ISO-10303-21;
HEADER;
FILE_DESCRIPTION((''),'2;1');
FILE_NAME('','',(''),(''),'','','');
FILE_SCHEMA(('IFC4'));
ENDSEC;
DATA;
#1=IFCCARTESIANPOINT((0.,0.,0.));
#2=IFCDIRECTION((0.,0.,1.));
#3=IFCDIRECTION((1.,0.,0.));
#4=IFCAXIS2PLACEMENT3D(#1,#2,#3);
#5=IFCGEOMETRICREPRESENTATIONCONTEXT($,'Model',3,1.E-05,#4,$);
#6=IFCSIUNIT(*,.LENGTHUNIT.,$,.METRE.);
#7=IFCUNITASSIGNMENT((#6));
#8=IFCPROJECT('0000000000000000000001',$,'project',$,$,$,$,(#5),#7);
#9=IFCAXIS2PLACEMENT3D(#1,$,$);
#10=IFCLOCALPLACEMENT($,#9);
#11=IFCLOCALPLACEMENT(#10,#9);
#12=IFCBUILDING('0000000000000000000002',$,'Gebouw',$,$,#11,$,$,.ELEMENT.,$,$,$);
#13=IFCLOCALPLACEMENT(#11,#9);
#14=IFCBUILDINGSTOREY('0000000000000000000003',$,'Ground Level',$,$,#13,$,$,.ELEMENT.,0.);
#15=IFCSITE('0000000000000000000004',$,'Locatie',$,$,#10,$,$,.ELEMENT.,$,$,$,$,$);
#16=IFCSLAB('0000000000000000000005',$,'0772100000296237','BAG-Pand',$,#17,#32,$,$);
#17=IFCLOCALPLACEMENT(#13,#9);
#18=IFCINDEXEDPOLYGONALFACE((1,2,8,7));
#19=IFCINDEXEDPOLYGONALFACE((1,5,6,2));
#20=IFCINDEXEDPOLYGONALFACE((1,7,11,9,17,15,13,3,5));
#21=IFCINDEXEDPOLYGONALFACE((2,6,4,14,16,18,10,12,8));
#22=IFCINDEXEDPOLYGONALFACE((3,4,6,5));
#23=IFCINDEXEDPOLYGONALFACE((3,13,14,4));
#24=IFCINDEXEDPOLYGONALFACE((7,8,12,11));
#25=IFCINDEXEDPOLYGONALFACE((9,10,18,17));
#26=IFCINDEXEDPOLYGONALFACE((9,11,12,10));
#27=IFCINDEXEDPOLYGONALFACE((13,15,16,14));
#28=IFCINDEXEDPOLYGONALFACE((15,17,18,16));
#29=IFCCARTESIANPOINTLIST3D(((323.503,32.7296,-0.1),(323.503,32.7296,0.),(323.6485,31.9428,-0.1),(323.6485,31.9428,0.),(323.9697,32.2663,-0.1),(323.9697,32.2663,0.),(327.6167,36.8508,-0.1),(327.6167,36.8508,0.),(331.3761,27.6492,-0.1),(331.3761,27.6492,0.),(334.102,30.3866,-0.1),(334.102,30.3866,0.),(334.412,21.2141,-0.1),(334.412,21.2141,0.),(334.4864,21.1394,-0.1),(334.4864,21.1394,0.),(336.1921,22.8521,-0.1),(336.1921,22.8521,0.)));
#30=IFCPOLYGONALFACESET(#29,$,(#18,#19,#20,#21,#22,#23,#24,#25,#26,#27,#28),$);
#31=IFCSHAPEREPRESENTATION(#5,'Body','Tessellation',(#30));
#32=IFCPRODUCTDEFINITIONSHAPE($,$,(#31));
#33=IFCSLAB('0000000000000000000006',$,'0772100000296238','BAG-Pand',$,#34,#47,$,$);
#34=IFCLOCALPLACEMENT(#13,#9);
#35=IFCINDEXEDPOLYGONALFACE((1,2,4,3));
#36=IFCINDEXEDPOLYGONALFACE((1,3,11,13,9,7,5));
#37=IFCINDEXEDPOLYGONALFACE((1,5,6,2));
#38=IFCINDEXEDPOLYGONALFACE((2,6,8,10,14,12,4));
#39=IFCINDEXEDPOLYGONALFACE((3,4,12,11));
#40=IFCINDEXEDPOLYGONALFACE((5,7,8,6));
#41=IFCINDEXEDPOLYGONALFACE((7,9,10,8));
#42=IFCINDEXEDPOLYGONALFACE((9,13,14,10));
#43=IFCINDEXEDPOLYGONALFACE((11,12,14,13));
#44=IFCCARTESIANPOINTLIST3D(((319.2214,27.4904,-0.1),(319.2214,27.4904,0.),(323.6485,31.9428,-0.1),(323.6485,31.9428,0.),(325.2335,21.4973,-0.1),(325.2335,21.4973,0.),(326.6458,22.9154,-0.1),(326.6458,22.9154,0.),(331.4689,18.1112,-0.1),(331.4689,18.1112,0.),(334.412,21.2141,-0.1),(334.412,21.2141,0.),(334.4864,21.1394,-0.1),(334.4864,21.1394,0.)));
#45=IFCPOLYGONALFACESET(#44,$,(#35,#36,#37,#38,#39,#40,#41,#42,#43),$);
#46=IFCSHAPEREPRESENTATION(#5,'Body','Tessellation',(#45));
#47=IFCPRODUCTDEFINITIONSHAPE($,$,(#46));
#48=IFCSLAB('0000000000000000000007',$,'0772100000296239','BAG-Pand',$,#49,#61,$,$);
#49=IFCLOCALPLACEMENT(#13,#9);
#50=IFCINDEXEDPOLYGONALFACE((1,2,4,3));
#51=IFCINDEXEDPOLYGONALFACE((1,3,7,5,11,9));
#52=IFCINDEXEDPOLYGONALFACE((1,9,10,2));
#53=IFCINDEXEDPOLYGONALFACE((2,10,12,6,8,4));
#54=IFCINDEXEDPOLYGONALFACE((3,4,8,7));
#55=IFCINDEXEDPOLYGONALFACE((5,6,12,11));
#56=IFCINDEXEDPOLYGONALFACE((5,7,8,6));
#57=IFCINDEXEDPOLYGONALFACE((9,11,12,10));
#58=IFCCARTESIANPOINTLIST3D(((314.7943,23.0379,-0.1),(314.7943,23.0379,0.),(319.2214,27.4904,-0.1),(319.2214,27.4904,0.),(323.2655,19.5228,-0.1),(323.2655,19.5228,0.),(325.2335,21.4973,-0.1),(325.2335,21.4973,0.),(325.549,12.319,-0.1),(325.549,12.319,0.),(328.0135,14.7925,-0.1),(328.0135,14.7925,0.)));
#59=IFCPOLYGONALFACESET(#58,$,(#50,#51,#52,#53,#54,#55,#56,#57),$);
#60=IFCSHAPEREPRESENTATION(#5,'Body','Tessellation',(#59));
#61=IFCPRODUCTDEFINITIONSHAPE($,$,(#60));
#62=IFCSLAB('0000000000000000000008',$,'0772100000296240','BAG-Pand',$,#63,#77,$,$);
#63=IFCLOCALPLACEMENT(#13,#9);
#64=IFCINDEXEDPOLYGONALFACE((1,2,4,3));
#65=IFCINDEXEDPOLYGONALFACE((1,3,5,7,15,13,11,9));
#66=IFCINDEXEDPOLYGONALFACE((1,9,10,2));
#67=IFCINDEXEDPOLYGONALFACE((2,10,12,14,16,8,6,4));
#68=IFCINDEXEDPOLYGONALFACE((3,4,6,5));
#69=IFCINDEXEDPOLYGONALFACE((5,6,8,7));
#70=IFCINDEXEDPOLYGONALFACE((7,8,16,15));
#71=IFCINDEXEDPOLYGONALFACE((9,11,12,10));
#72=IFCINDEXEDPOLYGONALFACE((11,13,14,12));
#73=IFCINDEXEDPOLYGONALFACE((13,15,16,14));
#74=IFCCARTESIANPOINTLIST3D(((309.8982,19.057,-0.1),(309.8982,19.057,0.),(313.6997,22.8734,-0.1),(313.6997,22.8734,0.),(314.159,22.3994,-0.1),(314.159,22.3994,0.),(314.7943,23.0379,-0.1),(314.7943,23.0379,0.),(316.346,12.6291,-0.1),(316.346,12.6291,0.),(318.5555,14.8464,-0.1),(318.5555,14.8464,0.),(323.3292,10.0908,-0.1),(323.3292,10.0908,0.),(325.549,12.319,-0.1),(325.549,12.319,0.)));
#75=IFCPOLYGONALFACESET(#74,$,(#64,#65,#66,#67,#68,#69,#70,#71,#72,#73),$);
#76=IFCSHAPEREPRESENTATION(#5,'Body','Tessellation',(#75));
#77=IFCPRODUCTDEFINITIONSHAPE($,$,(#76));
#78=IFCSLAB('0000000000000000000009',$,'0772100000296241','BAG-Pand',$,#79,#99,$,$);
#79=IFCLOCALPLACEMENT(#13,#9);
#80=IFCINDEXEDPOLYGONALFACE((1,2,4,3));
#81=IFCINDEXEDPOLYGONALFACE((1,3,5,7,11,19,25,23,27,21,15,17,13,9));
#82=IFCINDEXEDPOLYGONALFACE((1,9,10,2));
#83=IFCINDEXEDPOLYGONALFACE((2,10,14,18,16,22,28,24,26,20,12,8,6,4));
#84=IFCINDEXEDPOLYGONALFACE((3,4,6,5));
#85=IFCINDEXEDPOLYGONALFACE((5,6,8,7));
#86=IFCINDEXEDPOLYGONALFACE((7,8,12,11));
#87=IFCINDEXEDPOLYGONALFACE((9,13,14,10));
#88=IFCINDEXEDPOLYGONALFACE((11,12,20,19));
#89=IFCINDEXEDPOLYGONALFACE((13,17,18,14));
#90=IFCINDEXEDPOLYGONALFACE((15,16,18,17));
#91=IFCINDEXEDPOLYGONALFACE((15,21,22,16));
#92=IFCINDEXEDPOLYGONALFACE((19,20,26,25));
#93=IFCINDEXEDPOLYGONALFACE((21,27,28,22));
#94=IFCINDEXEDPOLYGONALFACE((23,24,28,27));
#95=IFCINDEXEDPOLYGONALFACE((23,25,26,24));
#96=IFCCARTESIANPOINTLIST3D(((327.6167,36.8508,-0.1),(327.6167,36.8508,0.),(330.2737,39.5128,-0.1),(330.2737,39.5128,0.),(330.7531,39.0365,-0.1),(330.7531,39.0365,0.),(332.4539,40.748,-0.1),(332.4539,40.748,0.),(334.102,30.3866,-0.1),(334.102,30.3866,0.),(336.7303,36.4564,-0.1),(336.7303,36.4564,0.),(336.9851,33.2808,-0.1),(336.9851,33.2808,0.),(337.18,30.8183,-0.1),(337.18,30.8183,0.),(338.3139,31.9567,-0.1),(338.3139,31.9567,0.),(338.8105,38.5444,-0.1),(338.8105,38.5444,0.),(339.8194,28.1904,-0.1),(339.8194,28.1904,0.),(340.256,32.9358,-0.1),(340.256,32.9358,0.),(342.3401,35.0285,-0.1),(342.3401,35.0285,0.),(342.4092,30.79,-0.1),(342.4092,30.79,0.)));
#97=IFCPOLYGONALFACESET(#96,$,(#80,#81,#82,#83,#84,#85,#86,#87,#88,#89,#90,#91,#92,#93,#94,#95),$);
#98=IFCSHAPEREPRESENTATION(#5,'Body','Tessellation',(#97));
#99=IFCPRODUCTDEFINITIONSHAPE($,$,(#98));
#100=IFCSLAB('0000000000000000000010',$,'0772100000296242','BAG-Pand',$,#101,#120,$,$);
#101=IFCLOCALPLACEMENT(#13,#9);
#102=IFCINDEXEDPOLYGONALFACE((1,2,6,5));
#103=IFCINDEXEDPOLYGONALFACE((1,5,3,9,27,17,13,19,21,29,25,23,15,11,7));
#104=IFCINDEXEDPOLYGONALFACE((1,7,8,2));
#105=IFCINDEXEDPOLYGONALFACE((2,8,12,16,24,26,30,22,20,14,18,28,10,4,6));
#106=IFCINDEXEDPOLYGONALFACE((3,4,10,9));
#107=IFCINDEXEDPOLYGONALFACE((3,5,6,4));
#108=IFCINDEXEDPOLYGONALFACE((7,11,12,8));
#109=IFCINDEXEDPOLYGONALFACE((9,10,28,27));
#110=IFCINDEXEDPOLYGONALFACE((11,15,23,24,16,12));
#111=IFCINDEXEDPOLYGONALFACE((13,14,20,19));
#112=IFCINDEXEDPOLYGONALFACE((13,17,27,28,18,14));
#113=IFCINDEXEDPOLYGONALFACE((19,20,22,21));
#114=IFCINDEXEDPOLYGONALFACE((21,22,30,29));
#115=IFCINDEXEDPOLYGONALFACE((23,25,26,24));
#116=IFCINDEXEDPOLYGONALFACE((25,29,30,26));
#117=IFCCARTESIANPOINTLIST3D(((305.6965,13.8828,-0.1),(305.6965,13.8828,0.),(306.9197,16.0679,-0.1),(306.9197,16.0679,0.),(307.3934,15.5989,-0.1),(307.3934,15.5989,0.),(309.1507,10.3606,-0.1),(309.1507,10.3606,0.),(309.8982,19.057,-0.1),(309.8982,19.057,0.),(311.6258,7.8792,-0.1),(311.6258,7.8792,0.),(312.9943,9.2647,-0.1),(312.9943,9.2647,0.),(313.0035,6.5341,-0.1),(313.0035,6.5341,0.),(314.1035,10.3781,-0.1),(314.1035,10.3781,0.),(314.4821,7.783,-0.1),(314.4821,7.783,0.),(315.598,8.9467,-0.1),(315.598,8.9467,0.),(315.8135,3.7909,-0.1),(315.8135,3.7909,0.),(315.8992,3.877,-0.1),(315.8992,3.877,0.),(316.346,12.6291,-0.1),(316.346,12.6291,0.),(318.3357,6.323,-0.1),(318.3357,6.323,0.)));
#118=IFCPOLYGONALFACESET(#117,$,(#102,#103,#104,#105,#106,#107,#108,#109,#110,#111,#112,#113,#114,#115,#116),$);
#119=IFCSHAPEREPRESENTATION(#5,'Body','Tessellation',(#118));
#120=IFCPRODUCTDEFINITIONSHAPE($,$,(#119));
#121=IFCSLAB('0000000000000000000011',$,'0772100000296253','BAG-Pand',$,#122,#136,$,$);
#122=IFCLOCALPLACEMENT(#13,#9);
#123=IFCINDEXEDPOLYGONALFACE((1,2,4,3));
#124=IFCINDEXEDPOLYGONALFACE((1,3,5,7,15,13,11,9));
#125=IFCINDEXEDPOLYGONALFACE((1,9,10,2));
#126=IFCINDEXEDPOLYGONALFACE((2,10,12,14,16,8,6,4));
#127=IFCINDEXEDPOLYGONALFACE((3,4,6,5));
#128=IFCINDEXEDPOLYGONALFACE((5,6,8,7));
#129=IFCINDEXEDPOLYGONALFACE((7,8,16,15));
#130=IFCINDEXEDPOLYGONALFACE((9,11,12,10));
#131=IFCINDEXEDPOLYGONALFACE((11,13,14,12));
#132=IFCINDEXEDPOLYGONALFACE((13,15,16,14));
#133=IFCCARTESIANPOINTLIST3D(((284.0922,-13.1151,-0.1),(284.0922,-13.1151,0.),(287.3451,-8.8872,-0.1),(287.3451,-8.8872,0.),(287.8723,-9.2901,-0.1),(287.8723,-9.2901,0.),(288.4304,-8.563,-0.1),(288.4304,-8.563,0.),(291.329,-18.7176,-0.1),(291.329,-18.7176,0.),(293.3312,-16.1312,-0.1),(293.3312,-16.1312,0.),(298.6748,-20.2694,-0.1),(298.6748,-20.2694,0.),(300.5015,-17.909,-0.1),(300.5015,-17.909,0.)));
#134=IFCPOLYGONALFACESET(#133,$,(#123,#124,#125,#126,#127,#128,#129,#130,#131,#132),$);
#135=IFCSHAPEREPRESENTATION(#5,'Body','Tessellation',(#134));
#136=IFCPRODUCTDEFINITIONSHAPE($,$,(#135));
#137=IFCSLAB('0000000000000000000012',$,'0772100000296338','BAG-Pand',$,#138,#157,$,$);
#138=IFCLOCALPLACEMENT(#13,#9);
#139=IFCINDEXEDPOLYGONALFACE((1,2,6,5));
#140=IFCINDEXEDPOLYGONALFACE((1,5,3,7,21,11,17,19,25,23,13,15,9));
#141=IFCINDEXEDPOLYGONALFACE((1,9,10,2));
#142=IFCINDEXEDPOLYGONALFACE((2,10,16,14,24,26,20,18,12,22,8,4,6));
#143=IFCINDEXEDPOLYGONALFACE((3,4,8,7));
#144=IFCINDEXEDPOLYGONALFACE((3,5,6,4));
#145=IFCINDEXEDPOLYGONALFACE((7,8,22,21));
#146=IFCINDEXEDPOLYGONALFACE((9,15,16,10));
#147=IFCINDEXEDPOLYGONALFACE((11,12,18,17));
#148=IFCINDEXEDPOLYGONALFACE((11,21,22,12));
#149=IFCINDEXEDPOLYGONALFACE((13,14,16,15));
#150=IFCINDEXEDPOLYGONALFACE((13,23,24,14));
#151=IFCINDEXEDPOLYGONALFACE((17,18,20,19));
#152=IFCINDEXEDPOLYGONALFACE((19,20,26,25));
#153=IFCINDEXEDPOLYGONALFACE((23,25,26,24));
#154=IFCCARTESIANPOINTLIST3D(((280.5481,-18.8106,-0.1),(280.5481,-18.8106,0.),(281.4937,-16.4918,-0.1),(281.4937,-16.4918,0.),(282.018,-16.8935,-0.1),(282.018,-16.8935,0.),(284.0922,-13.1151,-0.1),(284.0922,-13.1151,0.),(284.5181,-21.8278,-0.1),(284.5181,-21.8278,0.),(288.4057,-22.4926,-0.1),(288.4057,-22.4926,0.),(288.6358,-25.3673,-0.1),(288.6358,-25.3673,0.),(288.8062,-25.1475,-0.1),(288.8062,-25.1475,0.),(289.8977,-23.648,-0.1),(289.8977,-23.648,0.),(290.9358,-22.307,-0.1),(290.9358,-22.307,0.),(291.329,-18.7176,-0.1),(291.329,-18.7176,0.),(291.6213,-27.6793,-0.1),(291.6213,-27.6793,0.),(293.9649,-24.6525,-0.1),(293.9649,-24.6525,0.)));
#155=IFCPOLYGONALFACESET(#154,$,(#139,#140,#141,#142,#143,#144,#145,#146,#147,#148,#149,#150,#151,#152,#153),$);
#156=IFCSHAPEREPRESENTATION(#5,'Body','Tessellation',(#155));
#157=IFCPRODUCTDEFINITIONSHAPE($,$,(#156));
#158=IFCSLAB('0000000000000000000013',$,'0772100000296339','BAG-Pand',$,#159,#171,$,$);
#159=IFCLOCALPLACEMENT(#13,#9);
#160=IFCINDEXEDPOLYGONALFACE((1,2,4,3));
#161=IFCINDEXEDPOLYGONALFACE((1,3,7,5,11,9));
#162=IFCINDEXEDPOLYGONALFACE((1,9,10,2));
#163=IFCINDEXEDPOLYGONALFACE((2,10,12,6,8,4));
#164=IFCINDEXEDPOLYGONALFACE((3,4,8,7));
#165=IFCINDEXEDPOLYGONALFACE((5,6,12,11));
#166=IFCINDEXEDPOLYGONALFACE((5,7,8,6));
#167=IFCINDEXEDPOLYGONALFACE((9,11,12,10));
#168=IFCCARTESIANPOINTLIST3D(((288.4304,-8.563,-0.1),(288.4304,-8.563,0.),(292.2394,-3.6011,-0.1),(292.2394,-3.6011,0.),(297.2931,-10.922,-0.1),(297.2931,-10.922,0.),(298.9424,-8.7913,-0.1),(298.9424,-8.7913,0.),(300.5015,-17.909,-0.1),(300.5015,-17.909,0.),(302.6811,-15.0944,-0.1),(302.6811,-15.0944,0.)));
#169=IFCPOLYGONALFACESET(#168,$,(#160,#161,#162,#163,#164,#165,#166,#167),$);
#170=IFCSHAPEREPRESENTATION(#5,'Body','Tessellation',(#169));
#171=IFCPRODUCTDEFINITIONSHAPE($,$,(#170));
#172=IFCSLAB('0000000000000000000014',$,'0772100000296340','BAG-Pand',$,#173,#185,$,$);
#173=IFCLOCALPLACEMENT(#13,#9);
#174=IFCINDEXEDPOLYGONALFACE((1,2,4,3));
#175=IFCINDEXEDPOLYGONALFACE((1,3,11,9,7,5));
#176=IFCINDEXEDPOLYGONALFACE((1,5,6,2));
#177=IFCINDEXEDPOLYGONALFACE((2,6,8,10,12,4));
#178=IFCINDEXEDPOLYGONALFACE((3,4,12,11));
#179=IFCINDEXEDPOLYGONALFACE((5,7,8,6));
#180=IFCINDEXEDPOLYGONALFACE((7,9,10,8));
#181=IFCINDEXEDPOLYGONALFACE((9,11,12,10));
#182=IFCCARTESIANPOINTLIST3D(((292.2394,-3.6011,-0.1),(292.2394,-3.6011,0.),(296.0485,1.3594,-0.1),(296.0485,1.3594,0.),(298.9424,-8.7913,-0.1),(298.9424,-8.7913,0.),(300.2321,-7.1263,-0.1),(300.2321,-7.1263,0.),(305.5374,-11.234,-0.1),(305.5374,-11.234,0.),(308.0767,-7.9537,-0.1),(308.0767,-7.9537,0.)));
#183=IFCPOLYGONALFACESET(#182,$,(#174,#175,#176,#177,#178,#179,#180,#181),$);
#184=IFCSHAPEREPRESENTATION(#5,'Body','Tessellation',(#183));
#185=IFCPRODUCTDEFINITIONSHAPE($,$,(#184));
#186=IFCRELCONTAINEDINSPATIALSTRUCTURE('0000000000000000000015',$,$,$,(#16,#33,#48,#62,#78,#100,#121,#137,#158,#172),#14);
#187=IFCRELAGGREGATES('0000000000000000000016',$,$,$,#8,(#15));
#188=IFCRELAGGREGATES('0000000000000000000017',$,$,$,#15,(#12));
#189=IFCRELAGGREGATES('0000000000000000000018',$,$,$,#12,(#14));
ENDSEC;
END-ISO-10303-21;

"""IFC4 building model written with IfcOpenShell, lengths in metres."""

from ifc_helpers import new_model, si_unit, frame, origin, origin_with_axes, place, context, project, spatial, polyline, outline, extrude, element, save


model = new_model("IFC4")

# Units and contexts
model_context = context("Model", 3, precision=1e-05, world=origin_with_axes())
ifc_project = project(units=[si_unit("LENGTHUNIT", "METRE")], contexts=[model_context])

# Site, building, storey
site_placement = place(None, origin())
site = spatial("IfcSite", under=ifc_project, at=site_placement, Name="Locatie", CompositionType="ELEMENT")
building_placement = place(site_placement, origin())
building = spatial("IfcBuilding", under=site, at=building_placement, Name="Gebouw", CompositionType="ELEMENT")
storey_placement = place(building_placement, origin())
storey = spatial("IfcBuildingStorey", under=building, at=storey_placement, Name="Ground Level", CompositionType="ELEMENT", Elevation=0.0)

# Slabs
slab_1_placement = place(storey_placement, origin())
element("IfcSlab", 1, at=slab_1_placement, inside=storey, Name="0772100000296237", Description="BAG-Pand", context=model_context, shape_type="SweptSolid", body=[
    extrude(outline(polyline([(334.412, 21.2141), (323.6485, 31.9428), (323.9697, 32.2663), (323.503, 32.7296), (327.6167, 36.8508), (334.102, 30.3866), (331.3761, 27.6492), (336.1921, 22.8521), (334.4864, 21.1394), (334.412, 21.2141)])), frame((0.0, 0.0, -0.1), z_axis=(0.0, 0.0, 1.0), x_axis=(1.0, 0.0, 0.0)), (0.0, 0.0, 1.0), 0.1),
])
slab_2_placement = place(storey_placement, origin())
element("IfcSlab", 2, at=slab_2_placement, inside=storey, Name="0772100000296238", Description="BAG-Pand", context=model_context, shape_type="SweptSolid", body=[
    extrude(outline(polyline([(319.2214, 27.4904), (323.6485, 31.9428), (334.412, 21.2141), (334.4864, 21.1394), (331.4689, 18.1112), (326.6458, 22.9154), (325.2335, 21.4973), (319.2214, 27.4904)])), frame((0.0, 0.0, -0.1), z_axis=(0.0, 0.0, 1.0), x_axis=(1.0, 0.0, 0.0)), (0.0, 0.0, 1.0), 0.1),
])
slab_3_placement = place(storey_placement, origin())
element("IfcSlab", 3, at=slab_3_placement, inside=storey, Name="0772100000296239", Description="BAG-Pand", context=model_context, shape_type="SweptSolid", body=[
    extrude(outline(polyline([(314.7943, 23.0379), (319.2214, 27.4904), (325.2335, 21.4973), (323.2655, 19.5228), (328.0135, 14.7925), (325.549, 12.319), (314.7943, 23.0379)])), frame((0.0, 0.0, -0.1), z_axis=(0.0, 0.0, 1.0), x_axis=(1.0, 0.0, 0.0)), (0.0, 0.0, 1.0), 0.1),
])
slab_4_placement = place(storey_placement, origin())
element("IfcSlab", 4, at=slab_4_placement, inside=storey, Name="0772100000296240", Description="BAG-Pand", context=model_context, shape_type="SweptSolid", body=[
    extrude(outline(polyline([(309.8982, 19.057), (313.6997, 22.8734), (314.159, 22.3994), (314.7943, 23.0379), (325.549, 12.319), (323.3292, 10.0908), (318.5555, 14.8464), (316.346, 12.6291), (309.8982, 19.057)])), frame((0.0, 0.0, -0.1), z_axis=(0.0, 0.0, 1.0), x_axis=(1.0, 0.0, 0.0)), (0.0, 0.0, 1.0), 0.1),
])
slab_5_placement = place(storey_placement, origin())
element("IfcSlab", 5, at=slab_5_placement, inside=storey, Name="0772100000296241", Description="BAG-Pand", context=model_context, shape_type="SweptSolid", body=[
    extrude(outline(polyline([(327.6167, 36.8508), (330.2737, 39.5128), (330.7531, 39.0365), (332.4539, 40.748), (336.7303, 36.4564), (338.8105, 38.5444), (342.3401, 35.0285), (340.256, 32.9358), (342.4092, 30.79), (339.8194, 28.1904), (337.18, 30.8183), (338.3139, 31.9567), (336.9851, 33.2808), (334.102, 30.3866), (327.6167, 36.8508)])), frame((0.0, 0.0, -0.1), z_axis=(0.0, 0.0, 1.0), x_axis=(1.0, 0.0, 0.0)), (0.0, 0.0, 1.0), 0.1),
])
slab_6_placement = place(storey_placement, origin())
element("IfcSlab", 6, at=slab_6_placement, inside=storey, Name="0772100000296242", Description="BAG-Pand", context=model_context, shape_type="SweptSolid", body=[
    extrude(outline(polyline([(313.0035, 6.5341), (311.6258, 7.8792), (309.1507, 10.3606), (305.6965, 13.8828), (307.3934, 15.5989), (306.9197, 16.0679), (309.8982, 19.057), (316.346, 12.6291), (314.1035, 10.3781), (312.9943, 9.2647), (314.4821, 7.783), (315.598, 8.9467), (318.3357, 6.323), (315.8992, 3.877), (315.8135, 3.7909), (313.0035, 6.5341)])), frame((0.0, 0.0, -0.1), z_axis=(0.0, 0.0, 1.0), x_axis=(1.0, 0.0, 0.0)), (0.0, 0.0, 1.0), 0.1),
])
slab_7_placement = place(storey_placement, origin())
element("IfcSlab", 7, at=slab_7_placement, inside=storey, Name="0772100000296253", Description="BAG-Pand", context=model_context, shape_type="SweptSolid", body=[
    extrude(outline(polyline([(287.3451, -8.8872), (287.8723, -9.2901), (288.4304, -8.563), (300.5015, -17.909), (298.6748, -20.2694), (293.3312, -16.1312), (291.329, -18.7176), (284.0922, -13.1151), (287.3451, -8.8872)])), frame((0.0, 0.0, -0.1), z_axis=(0.0, 0.0, 1.0), x_axis=(1.0, 0.0, 0.0)), (0.0, 0.0, 1.0), 0.1),
])
slab_8_placement = place(storey_placement, origin())
element("IfcSlab", 8, at=slab_8_placement, inside=storey, Name="0772100000296338", Description="BAG-Pand", context=model_context, shape_type="SweptSolid", body=[
    extrude(outline(polyline([(282.018, -16.8935), (281.4937, -16.4918), (284.0922, -13.1151), (291.329, -18.7176), (288.4057, -22.4926), (289.8977, -23.648), (290.9358, -22.307), (293.9649, -24.6525), (291.6213, -27.6793), (288.6358, -25.3673), (288.8062, -25.1475), (284.5181, -21.8278), (280.5481, -18.8106), (282.018, -16.8935)])), frame((0.0, 0.0, -0.1), z_axis=(0.0, 0.0, 1.0), x_axis=(1.0, 0.0, 0.0)), (0.0, 0.0, 1.0), 0.1),
])
slab_9_placement = place(storey_placement, origin())
element("IfcSlab", 9, at=slab_9_placement, inside=storey, Name="0772100000296339", Description="BAG-Pand", context=model_context, shape_type="SweptSolid", body=[
    extrude(outline(polyline([(292.2394, -3.6011), (298.9424, -8.7913), (297.2931, -10.922), (302.6811, -15.0944), (300.5015, -17.909), (288.4304, -8.563), (292.2394, -3.6011)])), frame((0.0, 0.0, -0.1), z_axis=(0.0, 0.0, 1.0), x_axis=(1.0, 0.0, 0.0)), (0.0, 0.0, 1.0), 0.1),
])
slab_10_placement = place(storey_placement, origin())
element("IfcSlab", 10, at=slab_10_placement, inside=storey, Name="0772100000296340", Description="BAG-Pand", context=model_context, shape_type="SweptSolid", body=[
    extrude(outline(polyline([(296.0485, 1.3594), (308.0767, -7.9537), (305.5374, -11.234), (300.2321, -7.1263), (298.9424, -8.7913), (292.2394, -3.6011), (296.0485, 1.3594)])), frame((0.0, 0.0, -0.1), z_axis=(0.0, 0.0, 1.0), x_axis=(1.0, 0.0, 0.0)), (0.0, 0.0, 1.0), 0.1),
])

save(model, "model.ifc")
